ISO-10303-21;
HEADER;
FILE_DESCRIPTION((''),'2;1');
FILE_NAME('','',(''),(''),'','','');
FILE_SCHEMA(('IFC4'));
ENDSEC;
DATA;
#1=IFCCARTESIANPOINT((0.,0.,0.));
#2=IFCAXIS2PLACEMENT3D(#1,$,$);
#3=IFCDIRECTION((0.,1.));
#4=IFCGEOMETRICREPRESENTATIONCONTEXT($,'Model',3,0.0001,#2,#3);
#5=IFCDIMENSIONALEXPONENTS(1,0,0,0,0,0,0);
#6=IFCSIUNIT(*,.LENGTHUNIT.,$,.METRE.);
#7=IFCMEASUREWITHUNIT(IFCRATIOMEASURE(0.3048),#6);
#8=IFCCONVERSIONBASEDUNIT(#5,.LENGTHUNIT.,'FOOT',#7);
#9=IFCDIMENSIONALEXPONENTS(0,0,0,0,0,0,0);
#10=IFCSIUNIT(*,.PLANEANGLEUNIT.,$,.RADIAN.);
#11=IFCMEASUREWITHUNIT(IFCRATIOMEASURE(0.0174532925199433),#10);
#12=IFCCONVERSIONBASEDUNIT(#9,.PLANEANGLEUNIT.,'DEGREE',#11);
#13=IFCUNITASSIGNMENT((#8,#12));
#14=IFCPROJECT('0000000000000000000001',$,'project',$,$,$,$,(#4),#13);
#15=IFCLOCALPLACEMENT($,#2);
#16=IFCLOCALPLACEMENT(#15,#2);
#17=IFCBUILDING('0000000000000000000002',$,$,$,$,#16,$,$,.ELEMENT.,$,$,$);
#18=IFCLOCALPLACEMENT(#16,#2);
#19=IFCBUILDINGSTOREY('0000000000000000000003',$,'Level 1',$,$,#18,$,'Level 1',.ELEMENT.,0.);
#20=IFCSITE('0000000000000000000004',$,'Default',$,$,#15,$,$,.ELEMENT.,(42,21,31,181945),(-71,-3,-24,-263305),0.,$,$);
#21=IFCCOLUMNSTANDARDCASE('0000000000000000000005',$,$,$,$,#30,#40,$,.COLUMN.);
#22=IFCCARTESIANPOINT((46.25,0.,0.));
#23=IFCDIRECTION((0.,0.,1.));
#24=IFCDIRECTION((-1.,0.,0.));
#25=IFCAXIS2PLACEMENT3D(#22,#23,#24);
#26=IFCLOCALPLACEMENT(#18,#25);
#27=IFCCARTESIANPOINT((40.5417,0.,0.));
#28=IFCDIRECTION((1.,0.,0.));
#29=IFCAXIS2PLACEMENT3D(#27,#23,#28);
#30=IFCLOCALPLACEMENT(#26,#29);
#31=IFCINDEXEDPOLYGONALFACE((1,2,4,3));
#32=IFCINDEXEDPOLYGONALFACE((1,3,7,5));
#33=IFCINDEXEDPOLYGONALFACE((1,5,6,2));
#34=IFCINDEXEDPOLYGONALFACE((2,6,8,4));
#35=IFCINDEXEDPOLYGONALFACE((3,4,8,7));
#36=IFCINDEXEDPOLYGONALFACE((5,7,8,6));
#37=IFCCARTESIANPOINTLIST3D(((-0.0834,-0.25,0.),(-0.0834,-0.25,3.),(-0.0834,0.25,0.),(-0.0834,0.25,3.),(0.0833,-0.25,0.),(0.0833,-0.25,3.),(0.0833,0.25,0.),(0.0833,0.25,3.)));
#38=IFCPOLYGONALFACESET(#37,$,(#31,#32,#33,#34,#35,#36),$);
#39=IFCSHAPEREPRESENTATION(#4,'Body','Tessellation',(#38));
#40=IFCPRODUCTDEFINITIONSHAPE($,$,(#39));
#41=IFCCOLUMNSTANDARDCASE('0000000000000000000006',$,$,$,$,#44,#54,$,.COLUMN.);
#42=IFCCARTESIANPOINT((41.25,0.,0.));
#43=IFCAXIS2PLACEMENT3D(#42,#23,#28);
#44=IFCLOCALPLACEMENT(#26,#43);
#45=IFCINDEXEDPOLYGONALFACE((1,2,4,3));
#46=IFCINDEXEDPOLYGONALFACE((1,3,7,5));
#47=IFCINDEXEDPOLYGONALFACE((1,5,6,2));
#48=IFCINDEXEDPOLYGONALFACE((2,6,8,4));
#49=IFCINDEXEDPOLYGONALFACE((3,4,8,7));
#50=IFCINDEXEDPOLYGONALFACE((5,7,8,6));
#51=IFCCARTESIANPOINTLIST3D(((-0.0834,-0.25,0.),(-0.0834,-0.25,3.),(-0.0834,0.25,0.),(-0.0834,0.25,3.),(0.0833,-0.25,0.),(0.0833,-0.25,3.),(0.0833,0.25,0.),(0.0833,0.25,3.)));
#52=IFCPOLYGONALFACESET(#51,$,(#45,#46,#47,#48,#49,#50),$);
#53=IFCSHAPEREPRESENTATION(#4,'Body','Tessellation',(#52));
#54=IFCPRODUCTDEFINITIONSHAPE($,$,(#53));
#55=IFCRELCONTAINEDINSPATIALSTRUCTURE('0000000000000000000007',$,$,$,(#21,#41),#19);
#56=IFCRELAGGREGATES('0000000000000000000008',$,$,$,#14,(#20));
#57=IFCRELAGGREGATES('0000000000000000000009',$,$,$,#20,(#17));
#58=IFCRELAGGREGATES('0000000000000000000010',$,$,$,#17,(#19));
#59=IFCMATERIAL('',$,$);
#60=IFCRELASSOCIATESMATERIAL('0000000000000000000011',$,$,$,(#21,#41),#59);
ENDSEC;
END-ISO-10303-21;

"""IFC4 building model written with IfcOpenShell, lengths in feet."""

from ifc_helpers import new_model, entity, si_unit, converted_unit, direction, frame, origin, place, context, project, spatial, rectangle, extrude, material, element, save


model = new_model("IFC4")

# Units and contexts
model_context = context("Model", 3, precision=0.0001, world=origin(), true_north=direction((0.0, 1.0)))
ifc_project = project(units=[converted_unit("LENGTHUNIT", "FOOT", entity("IfcRatioMeasure", 0.3048), si_unit("LENGTHUNIT", "METRE"), dimensions=[1, 0, 0, 0, 0, 0, 0]), converted_unit("PLANEANGLEUNIT", "DEGREE", entity("IfcRatioMeasure", 0.0174532925199433), si_unit("PLANEANGLEUNIT", "RADIAN"), dimensions=[0, 0, 0, 0, 0, 0, 0])], contexts=[model_context])

# Site, building, storey
site_placement = place(None, origin())
site = spatial("IfcSite", under=ifc_project, at=site_placement, Name="Default", CompositionType="ELEMENT", RefLatitude=(42, 21, 31, 181945), RefLongitude=(-71, -3, -24, -263305), RefElevation=0.0)
building_placement = place(site_placement, origin())
building = spatial("IfcBuilding", under=site, at=building_placement, CompositionType="ELEMENT")
storey_placement = place(building_placement, origin())
storey = spatial("IfcBuildingStorey", under=building, at=storey_placement, Name="Level 1", LongName="Level 1", CompositionType="ELEMENT", Elevation=0.0)

# Columns
ifc_material_1 = material(Name="")
placement = place(storey_placement, frame((46.25, 0.0, 0.0), z_axis=(0.0, 0.0, 1.0), x_axis=(-1.0, 0.0, 0.0)))
for number, where, z_axis, x_axis in (
    (1, (40.5417, 0.0, 0.0), (0.0, 0.0, 1.0), (1.0, 0.0, 0.0)),
    (2, (41.25, 0.0, 0.0), (0.0, 0.0, 1.0), (1.0, 0.0, 0.0)),
):
    element("IfcColumnStandardCase", number, at=place(placement, frame(where, z_axis=z_axis, x_axis=x_axis)), inside=storey, material=ifc_material_1, PredefinedType="COLUMN", context=model_context, shape_type="SweptSolid", body=[
        extrude(rectangle(XDim=0.1667, YDim=0.5), origin(), (0.0, 0.0, 1.0), 3.0),
    ])

save(model, "model.ifc")
